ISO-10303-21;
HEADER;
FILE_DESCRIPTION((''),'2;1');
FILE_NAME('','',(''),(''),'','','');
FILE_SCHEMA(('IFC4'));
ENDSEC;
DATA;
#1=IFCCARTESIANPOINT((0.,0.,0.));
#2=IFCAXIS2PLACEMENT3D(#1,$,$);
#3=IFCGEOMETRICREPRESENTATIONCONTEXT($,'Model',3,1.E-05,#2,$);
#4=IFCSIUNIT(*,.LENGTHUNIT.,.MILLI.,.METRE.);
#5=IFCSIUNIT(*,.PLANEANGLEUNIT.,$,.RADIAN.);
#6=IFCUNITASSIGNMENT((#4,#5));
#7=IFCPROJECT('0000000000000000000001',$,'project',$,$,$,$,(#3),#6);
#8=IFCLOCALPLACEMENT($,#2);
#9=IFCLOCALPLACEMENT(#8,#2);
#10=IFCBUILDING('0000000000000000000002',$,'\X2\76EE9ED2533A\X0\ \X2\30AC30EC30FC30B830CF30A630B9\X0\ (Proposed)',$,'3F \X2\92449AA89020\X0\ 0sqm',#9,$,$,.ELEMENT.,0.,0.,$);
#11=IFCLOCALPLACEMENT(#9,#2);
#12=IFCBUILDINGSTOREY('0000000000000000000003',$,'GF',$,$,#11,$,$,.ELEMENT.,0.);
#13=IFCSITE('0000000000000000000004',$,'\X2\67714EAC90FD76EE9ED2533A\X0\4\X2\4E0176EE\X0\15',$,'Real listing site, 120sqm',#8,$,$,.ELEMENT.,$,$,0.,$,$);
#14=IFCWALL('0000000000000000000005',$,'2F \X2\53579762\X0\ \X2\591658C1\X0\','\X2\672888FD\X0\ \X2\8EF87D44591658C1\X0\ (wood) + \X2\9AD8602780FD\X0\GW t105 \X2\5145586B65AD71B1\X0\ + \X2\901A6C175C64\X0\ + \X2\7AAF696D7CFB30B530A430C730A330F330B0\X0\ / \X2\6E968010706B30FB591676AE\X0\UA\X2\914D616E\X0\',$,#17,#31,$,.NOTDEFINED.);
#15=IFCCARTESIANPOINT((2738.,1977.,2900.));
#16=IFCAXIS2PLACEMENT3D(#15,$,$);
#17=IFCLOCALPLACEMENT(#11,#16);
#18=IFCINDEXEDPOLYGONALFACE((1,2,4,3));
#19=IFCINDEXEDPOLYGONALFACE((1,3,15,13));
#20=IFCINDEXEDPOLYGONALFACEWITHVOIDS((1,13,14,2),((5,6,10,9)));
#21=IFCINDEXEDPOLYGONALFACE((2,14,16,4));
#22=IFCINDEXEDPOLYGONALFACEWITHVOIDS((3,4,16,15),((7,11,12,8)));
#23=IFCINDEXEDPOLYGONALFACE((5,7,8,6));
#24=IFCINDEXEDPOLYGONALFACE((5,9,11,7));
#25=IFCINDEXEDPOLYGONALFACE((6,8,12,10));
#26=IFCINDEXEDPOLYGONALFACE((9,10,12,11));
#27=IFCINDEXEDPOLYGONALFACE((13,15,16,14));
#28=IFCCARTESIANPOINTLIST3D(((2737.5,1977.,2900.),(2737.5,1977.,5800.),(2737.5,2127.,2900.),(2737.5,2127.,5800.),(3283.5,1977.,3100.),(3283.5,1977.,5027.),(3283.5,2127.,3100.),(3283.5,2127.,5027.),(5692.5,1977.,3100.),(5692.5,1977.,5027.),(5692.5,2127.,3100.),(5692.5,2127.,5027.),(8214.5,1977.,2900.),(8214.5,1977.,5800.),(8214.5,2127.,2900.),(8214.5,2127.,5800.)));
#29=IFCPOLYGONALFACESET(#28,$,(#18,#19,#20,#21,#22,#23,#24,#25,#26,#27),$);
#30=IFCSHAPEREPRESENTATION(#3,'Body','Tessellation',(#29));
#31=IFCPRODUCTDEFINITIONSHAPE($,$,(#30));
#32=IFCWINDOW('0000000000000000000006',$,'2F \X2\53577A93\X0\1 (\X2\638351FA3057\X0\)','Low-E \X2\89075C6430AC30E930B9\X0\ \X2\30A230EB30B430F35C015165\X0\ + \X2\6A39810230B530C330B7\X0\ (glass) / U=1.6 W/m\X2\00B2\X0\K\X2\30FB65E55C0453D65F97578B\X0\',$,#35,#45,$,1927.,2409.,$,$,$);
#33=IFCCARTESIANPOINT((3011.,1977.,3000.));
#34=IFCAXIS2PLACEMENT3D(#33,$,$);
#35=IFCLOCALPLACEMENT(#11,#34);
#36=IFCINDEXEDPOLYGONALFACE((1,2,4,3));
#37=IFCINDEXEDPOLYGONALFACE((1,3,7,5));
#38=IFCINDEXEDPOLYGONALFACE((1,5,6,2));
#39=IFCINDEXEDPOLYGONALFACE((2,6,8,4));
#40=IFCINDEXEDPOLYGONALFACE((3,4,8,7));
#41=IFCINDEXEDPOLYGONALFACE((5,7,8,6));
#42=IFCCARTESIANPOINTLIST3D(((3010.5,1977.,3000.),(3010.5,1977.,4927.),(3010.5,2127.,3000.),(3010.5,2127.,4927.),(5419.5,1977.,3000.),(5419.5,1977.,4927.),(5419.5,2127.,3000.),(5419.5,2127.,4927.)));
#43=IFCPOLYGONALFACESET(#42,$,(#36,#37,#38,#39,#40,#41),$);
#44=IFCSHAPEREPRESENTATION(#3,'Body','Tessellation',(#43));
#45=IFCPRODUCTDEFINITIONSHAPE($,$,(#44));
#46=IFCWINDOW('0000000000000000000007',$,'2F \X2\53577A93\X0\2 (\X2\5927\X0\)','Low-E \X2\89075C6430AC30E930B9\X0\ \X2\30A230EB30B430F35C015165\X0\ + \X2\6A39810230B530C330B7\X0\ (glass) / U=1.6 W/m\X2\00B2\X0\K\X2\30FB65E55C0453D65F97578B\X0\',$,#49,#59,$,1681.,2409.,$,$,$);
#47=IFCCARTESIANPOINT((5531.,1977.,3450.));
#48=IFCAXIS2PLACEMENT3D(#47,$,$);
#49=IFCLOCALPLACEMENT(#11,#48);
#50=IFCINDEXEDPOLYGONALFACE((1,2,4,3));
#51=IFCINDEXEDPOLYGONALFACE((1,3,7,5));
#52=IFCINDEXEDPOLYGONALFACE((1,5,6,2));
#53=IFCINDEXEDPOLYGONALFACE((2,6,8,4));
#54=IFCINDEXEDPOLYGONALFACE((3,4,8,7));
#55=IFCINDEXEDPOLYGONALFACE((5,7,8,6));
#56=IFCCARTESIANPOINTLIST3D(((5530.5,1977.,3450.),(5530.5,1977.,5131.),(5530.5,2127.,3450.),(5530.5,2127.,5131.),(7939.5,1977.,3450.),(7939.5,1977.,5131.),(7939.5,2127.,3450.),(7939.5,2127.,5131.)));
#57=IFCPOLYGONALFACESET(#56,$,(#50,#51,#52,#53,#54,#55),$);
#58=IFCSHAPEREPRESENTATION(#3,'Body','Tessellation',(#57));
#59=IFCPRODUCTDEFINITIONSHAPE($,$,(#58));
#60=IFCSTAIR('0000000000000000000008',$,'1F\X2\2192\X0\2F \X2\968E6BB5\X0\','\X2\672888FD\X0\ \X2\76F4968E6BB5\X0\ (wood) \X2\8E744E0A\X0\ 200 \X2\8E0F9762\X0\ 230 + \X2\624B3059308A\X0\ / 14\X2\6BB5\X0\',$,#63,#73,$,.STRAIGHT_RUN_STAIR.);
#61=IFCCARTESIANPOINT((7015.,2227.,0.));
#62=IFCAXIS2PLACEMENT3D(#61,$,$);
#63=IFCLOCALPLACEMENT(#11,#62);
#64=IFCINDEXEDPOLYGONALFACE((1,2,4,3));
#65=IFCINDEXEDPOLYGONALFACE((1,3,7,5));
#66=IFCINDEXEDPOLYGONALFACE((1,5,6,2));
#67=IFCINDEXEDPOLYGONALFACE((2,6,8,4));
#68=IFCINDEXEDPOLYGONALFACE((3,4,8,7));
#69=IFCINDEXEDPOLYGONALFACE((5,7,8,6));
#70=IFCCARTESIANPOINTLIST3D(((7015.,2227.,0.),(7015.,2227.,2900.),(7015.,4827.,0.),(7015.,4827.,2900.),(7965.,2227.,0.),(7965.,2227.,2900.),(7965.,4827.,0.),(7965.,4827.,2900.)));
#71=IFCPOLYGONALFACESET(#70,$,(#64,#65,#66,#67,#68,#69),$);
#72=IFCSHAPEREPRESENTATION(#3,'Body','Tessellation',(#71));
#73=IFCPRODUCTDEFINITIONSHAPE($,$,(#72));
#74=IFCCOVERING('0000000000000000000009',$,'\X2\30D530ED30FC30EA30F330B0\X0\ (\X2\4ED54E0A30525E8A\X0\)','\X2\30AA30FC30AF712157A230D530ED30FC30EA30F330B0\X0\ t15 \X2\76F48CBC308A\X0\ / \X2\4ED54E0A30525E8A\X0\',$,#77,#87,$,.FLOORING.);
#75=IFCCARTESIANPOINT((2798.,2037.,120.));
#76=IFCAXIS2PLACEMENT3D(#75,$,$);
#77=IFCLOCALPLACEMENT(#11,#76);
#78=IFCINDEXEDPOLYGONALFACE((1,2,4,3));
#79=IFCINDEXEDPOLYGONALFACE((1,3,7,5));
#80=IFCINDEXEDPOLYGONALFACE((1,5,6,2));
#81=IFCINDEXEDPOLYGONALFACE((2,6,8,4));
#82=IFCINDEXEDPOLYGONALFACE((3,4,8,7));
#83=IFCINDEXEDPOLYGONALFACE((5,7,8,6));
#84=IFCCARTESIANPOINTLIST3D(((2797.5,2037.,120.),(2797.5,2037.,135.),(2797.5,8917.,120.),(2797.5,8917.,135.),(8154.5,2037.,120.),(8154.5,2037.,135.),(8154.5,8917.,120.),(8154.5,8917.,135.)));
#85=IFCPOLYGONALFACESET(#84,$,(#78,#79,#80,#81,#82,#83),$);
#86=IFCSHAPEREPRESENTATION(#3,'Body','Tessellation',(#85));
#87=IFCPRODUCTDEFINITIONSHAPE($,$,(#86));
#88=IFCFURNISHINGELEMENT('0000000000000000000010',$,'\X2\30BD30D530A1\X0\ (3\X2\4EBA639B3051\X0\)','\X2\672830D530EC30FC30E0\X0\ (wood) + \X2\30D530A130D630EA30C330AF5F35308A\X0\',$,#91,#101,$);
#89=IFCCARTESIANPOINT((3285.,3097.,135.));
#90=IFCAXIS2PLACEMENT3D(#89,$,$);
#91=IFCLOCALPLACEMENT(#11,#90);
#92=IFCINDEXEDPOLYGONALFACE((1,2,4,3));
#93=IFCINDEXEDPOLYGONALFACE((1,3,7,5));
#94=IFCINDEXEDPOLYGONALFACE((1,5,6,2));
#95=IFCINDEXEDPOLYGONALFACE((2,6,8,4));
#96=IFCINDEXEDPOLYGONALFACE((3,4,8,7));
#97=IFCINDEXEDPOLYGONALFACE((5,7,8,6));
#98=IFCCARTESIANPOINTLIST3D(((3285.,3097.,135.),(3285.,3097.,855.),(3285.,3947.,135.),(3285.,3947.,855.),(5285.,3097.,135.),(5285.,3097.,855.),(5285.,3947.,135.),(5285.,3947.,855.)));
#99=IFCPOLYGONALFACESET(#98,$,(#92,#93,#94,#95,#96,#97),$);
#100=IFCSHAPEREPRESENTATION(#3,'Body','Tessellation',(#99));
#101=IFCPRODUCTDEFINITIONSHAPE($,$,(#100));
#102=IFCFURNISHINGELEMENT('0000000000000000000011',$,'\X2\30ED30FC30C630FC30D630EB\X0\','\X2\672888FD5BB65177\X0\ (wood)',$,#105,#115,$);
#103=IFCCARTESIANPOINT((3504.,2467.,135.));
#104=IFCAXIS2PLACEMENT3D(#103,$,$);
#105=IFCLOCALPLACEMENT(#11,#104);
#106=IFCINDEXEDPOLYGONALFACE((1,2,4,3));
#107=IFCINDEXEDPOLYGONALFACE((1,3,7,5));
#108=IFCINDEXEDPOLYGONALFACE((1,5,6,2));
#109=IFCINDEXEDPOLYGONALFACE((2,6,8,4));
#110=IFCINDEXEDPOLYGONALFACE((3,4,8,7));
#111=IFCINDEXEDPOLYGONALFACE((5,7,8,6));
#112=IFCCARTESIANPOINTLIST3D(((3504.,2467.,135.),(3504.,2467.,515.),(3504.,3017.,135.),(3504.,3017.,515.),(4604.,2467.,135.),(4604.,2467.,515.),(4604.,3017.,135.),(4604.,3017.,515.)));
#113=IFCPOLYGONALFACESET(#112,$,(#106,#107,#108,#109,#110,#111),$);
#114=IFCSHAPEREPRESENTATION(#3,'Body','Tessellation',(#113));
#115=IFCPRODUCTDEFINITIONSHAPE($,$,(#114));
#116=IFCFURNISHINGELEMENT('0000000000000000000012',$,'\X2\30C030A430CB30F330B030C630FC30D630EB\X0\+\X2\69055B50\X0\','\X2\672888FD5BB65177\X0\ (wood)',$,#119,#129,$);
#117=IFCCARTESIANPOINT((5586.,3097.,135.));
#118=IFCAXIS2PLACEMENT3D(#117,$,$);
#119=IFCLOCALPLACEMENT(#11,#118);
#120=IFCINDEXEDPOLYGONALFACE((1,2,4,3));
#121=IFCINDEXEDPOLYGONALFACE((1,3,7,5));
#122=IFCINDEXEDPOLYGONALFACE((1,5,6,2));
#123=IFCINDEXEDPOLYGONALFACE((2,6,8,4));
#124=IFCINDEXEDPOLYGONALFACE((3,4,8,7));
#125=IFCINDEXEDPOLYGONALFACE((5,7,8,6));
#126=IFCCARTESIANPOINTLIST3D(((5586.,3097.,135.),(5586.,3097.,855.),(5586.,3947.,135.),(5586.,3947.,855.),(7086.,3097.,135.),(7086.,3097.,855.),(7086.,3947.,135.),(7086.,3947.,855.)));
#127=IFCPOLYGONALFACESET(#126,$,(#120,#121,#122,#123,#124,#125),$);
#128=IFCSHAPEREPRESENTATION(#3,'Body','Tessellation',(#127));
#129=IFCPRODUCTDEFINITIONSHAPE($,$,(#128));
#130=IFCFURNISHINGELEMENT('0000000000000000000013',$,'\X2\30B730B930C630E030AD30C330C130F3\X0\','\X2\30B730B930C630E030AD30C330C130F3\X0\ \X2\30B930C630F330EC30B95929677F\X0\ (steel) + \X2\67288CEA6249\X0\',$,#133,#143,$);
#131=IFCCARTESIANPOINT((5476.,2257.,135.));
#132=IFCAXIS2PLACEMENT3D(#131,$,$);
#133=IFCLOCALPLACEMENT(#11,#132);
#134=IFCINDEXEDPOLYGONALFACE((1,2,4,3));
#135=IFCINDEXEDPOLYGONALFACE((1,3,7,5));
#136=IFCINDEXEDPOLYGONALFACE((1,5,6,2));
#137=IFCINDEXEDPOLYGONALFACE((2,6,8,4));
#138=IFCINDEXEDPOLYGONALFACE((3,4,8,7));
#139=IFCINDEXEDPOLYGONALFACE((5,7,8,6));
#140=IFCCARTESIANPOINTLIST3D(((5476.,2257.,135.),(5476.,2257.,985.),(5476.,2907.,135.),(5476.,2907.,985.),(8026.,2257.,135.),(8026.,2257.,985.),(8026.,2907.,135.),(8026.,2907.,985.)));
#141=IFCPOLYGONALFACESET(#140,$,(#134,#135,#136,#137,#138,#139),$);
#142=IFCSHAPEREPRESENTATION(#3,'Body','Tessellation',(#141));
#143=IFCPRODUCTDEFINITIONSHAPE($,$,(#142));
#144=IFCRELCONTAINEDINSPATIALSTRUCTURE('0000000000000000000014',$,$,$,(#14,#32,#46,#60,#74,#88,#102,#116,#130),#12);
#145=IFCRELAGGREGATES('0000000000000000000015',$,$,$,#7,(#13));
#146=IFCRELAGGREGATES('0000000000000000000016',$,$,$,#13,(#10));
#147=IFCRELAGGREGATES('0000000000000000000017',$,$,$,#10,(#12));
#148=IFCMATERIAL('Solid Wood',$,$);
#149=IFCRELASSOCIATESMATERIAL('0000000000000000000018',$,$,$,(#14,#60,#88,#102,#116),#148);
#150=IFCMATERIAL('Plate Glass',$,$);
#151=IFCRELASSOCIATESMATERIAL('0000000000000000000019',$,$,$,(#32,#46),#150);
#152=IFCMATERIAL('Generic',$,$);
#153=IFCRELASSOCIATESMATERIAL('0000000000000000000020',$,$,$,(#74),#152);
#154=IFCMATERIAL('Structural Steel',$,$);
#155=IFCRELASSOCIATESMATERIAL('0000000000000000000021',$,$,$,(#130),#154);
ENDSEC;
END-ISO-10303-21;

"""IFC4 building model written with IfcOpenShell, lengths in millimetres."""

from ifc_helpers import new_model, si_unit, frame, frame_2d, origin, place, context, project, spatial, rectangle, extrude, material, element, fill, save


model = new_model("IFC4")

# Units and contexts
model_context = context("Model", 3, precision=1e-05, world=origin())
ifc_project = project(units=[si_unit("LENGTHUNIT", "METRE", prefix="MILLI"), si_unit("PLANEANGLEUNIT", "RADIAN")], contexts=[model_context])

# Site, building, storey
site_placement = place(None, origin())
site = spatial("IfcSite", under=ifc_project, at=site_placement, Name="東京都目黒区4丁目15", ObjectType="Real listing site, 120sqm", CompositionType="ELEMENT", RefElevation=0.0)
building_placement = place(site_placement, origin())
building = spatial("IfcBuilding", under=site, at=building_placement, Name="目黒区 ガレージハウス (Proposed)", ObjectType="3F 鉄骨造 0sqm", CompositionType="ELEMENT", ElevationOfRefHeight=0.0, ElevationOfTerrain=0.0)
storey_placement = place(building_placement, origin())
storey = spatial("IfcBuildingStorey", under=building, at=storey_placement, Name="GF", CompositionType="ELEMENT", Elevation=0.0)

# Shared definitions
ifc_material_1 = material(Name="Solid Wood")

# Shared definitions
ifc_material_2 = material(Name="Plate Glass")

# Wall, openings, windows
wall_1_placement = place(storey_placement, frame((2738.0, 1977.0, 2900.0)))
wall_1 = element("IfcWall", 1, at=wall_1_placement, inside=storey, material=ifc_material_1, Name="2F 南面 外壁", Description="木製 軸組外壁 (wood) + 高性能GW t105 充填断熱 + 通気層 + 窯業系サイディング / 準耐火・外皮UA配慮", PredefinedType="NOTDEFINED", context=model_context, shape_type="SweptSolid", body=[
    extrude(rectangle(XDim=5477.0, YDim=150.0, at=frame_2d((2738.0, 75.0))), frame((2738.0, 1977.0, 2900.0)), (0.0, 0.0, 1.0), 2900.0),
])
opening_1_placement = place(storey_placement, frame((3011.0, 1977.0, 3000.0)))
opening_1 = element("IfcOpeningElement", 2, at=opening_1_placement, cuts=wall_1, PredefinedType="NOTDEFINED", context=model_context, shape_type="SweptSolid", body=[
    extrude(rectangle(XDim=2409.0, YDim=150.0, at=frame_2d((1204.0, 75.0))), frame((3011.0, 1977.0, 3000.0)), (0.0, 0.0, 1.0), 1927.0),
])
opening_2_placement = place(storey_placement, frame((5531.0, 1977.0, 3450.0)))
opening_2 = element("IfcOpeningElement", 3, at=opening_2_placement, cuts=wall_1, PredefinedType="NOTDEFINED", context=model_context, shape_type="SweptSolid", body=[
    extrude(rectangle(XDim=2409.0, YDim=150.0, at=frame_2d((1204.0, 75.0))), frame((5531.0, 1977.0, 3450.0)), (0.0, 0.0, 1.0), 1681.0),
])
window_1_placement = place(storey_placement, frame((3011.0, 1977.0, 3000.0)))
window_1 = element("IfcWindow", 4, at=window_1_placement, inside=storey, material=ifc_material_2, Name="2F 南窓1 (掃出し)", Description="Low-E 複層ガラス アルゴン封入 + 樹脂サッシ (glass) / U=1.6 W/m²K・日射取得型", OverallHeight=1927.0, OverallWidth=2409.0, context=model_context, shape_type="SweptSolid", body=[
    extrude(rectangle(XDim=2409.0, YDim=150.0, at=frame_2d((1204.0, 75.0))), frame((3011.0, 1977.0, 3000.0)), (0.0, 0.0, 1.0), 1927.0),
])
fill(opening_1, window_1)
window_2_placement = place(storey_placement, frame((5531.0, 1977.0, 3450.0)))
window_2 = element("IfcWindow", 5, at=window_2_placement, inside=storey, material=ifc_material_2, Name="2F 南窓2 (大)", Description="Low-E 複層ガラス アルゴン封入 + 樹脂サッシ (glass) / U=1.6 W/m²K・日射取得型", OverallHeight=1681.0, OverallWidth=2409.0, context=model_context, shape_type="SweptSolid", body=[
    extrude(rectangle(XDim=2409.0, YDim=150.0, at=frame_2d((1204.0, 75.0))), frame((5531.0, 1977.0, 3450.0)), (0.0, 0.0, 1.0), 1681.0),
])
fill(opening_2, window_2)

# Stair
stair_placement = place(storey_placement, frame((7015.0, 2227.0, 0.0)))
element("IfcStair", 6, at=stair_placement, inside=storey, material=ifc_material_1, Name="1F→2F 階段", Description="木製 直階段 (wood) 蹴上 200 踏面 230 + 手すり / 14段", PredefinedType="STRAIGHT_RUN_STAIR", context=model_context, shape_type="SweptSolid", body=[
    extrude(rectangle(XDim=950.0, YDim=2600.0, at=frame_2d((475.0, 1300.0))), frame((7015.0, 2227.0, 0.0)), (0.0, 0.0, 1.0), 2900.0),
])

# Covering
ifc_material_3 = material(Name="Generic")
covering_placement = place(storey_placement, frame((2798.0, 2037.0, 120.0)))
element("IfcCovering", 7, at=covering_placement, inside=storey, material=ifc_material_3, Name="フローリング (仕上げ床)", Description="オーク無垢フローリング t15 直貼り / 仕上げ床", PredefinedType="FLOORING", context=model_context, shape_type="SweptSolid", body=[
    extrude(rectangle(XDim=5357.0, YDim=6880.0, at=frame_2d((2678.0, 3440.0))), frame((2798.0, 2037.0, 120.0)), (0.0, 0.0, 1.0), 15.0),
])

# Furnishing elements
furnishing_1_placement = place(storey_placement, frame((3285.0, 3097.0, 135.0)))
element("IfcFurnishingElement", 8, at=furnishing_1_placement, inside=storey, material=ifc_material_1, Name="ソファ (3人掛け)", Description="木フレーム (wood) + ファブリック張り", context=model_context, shape_type="SweptSolid", body=[
    extrude(rectangle(XDim=2000.0, YDim=850.0, at=frame_2d((1000.0, 425.0))), frame((3285.0, 3097.0, 135.0)), (0.0, 0.0, 1.0), 720.0),
])
furnishing_2_placement = place(storey_placement, frame((3504.0, 2467.0, 135.0)))
element("IfcFurnishingElement", 9, at=furnishing_2_placement, inside=storey, material=ifc_material_1, Name="ローテーブル", Description="木製家具 (wood)", context=model_context, shape_type="SweptSolid", body=[
    extrude(rectangle(XDim=1100.0, YDim=550.0, at=frame_2d((550.0, 275.0))), frame((3504.0, 2467.0, 135.0)), (0.0, 0.0, 1.0), 380.0),
])
furnishing_3_placement = place(storey_placement, frame((5586.0, 3097.0, 135.0)))
element("IfcFurnishingElement", 10, at=furnishing_3_placement, inside=storey, material=ifc_material_1, Name="ダイニングテーブル+椅子", Description="木製家具 (wood)", context=model_context, shape_type="SweptSolid", body=[
    extrude(rectangle(XDim=1500.0, YDim=850.0, at=frame_2d((750.0, 425.0))), frame((5586.0, 3097.0, 135.0)), (0.0, 0.0, 1.0), 720.0),
])
ifc_material_4 = material(Name="Structural Steel")
furnishing_4_placement = place(storey_placement, frame((5476.0, 2257.0, 135.0)))
element("IfcFurnishingElement", 11, at=furnishing_4_placement, inside=storey, material=ifc_material_4, Name="システムキッチン", Description="システムキッチン ステンレス天板 (steel) + 木質扉", context=model_context, shape_type="SweptSolid", body=[
    extrude(rectangle(XDim=2550.0, YDim=650.0, at=frame_2d((1275.0, 325.0))), frame((5476.0, 2257.0, 135.0)), (0.0, 0.0, 1.0), 850.0),
])

save(model, "model.ifc")
